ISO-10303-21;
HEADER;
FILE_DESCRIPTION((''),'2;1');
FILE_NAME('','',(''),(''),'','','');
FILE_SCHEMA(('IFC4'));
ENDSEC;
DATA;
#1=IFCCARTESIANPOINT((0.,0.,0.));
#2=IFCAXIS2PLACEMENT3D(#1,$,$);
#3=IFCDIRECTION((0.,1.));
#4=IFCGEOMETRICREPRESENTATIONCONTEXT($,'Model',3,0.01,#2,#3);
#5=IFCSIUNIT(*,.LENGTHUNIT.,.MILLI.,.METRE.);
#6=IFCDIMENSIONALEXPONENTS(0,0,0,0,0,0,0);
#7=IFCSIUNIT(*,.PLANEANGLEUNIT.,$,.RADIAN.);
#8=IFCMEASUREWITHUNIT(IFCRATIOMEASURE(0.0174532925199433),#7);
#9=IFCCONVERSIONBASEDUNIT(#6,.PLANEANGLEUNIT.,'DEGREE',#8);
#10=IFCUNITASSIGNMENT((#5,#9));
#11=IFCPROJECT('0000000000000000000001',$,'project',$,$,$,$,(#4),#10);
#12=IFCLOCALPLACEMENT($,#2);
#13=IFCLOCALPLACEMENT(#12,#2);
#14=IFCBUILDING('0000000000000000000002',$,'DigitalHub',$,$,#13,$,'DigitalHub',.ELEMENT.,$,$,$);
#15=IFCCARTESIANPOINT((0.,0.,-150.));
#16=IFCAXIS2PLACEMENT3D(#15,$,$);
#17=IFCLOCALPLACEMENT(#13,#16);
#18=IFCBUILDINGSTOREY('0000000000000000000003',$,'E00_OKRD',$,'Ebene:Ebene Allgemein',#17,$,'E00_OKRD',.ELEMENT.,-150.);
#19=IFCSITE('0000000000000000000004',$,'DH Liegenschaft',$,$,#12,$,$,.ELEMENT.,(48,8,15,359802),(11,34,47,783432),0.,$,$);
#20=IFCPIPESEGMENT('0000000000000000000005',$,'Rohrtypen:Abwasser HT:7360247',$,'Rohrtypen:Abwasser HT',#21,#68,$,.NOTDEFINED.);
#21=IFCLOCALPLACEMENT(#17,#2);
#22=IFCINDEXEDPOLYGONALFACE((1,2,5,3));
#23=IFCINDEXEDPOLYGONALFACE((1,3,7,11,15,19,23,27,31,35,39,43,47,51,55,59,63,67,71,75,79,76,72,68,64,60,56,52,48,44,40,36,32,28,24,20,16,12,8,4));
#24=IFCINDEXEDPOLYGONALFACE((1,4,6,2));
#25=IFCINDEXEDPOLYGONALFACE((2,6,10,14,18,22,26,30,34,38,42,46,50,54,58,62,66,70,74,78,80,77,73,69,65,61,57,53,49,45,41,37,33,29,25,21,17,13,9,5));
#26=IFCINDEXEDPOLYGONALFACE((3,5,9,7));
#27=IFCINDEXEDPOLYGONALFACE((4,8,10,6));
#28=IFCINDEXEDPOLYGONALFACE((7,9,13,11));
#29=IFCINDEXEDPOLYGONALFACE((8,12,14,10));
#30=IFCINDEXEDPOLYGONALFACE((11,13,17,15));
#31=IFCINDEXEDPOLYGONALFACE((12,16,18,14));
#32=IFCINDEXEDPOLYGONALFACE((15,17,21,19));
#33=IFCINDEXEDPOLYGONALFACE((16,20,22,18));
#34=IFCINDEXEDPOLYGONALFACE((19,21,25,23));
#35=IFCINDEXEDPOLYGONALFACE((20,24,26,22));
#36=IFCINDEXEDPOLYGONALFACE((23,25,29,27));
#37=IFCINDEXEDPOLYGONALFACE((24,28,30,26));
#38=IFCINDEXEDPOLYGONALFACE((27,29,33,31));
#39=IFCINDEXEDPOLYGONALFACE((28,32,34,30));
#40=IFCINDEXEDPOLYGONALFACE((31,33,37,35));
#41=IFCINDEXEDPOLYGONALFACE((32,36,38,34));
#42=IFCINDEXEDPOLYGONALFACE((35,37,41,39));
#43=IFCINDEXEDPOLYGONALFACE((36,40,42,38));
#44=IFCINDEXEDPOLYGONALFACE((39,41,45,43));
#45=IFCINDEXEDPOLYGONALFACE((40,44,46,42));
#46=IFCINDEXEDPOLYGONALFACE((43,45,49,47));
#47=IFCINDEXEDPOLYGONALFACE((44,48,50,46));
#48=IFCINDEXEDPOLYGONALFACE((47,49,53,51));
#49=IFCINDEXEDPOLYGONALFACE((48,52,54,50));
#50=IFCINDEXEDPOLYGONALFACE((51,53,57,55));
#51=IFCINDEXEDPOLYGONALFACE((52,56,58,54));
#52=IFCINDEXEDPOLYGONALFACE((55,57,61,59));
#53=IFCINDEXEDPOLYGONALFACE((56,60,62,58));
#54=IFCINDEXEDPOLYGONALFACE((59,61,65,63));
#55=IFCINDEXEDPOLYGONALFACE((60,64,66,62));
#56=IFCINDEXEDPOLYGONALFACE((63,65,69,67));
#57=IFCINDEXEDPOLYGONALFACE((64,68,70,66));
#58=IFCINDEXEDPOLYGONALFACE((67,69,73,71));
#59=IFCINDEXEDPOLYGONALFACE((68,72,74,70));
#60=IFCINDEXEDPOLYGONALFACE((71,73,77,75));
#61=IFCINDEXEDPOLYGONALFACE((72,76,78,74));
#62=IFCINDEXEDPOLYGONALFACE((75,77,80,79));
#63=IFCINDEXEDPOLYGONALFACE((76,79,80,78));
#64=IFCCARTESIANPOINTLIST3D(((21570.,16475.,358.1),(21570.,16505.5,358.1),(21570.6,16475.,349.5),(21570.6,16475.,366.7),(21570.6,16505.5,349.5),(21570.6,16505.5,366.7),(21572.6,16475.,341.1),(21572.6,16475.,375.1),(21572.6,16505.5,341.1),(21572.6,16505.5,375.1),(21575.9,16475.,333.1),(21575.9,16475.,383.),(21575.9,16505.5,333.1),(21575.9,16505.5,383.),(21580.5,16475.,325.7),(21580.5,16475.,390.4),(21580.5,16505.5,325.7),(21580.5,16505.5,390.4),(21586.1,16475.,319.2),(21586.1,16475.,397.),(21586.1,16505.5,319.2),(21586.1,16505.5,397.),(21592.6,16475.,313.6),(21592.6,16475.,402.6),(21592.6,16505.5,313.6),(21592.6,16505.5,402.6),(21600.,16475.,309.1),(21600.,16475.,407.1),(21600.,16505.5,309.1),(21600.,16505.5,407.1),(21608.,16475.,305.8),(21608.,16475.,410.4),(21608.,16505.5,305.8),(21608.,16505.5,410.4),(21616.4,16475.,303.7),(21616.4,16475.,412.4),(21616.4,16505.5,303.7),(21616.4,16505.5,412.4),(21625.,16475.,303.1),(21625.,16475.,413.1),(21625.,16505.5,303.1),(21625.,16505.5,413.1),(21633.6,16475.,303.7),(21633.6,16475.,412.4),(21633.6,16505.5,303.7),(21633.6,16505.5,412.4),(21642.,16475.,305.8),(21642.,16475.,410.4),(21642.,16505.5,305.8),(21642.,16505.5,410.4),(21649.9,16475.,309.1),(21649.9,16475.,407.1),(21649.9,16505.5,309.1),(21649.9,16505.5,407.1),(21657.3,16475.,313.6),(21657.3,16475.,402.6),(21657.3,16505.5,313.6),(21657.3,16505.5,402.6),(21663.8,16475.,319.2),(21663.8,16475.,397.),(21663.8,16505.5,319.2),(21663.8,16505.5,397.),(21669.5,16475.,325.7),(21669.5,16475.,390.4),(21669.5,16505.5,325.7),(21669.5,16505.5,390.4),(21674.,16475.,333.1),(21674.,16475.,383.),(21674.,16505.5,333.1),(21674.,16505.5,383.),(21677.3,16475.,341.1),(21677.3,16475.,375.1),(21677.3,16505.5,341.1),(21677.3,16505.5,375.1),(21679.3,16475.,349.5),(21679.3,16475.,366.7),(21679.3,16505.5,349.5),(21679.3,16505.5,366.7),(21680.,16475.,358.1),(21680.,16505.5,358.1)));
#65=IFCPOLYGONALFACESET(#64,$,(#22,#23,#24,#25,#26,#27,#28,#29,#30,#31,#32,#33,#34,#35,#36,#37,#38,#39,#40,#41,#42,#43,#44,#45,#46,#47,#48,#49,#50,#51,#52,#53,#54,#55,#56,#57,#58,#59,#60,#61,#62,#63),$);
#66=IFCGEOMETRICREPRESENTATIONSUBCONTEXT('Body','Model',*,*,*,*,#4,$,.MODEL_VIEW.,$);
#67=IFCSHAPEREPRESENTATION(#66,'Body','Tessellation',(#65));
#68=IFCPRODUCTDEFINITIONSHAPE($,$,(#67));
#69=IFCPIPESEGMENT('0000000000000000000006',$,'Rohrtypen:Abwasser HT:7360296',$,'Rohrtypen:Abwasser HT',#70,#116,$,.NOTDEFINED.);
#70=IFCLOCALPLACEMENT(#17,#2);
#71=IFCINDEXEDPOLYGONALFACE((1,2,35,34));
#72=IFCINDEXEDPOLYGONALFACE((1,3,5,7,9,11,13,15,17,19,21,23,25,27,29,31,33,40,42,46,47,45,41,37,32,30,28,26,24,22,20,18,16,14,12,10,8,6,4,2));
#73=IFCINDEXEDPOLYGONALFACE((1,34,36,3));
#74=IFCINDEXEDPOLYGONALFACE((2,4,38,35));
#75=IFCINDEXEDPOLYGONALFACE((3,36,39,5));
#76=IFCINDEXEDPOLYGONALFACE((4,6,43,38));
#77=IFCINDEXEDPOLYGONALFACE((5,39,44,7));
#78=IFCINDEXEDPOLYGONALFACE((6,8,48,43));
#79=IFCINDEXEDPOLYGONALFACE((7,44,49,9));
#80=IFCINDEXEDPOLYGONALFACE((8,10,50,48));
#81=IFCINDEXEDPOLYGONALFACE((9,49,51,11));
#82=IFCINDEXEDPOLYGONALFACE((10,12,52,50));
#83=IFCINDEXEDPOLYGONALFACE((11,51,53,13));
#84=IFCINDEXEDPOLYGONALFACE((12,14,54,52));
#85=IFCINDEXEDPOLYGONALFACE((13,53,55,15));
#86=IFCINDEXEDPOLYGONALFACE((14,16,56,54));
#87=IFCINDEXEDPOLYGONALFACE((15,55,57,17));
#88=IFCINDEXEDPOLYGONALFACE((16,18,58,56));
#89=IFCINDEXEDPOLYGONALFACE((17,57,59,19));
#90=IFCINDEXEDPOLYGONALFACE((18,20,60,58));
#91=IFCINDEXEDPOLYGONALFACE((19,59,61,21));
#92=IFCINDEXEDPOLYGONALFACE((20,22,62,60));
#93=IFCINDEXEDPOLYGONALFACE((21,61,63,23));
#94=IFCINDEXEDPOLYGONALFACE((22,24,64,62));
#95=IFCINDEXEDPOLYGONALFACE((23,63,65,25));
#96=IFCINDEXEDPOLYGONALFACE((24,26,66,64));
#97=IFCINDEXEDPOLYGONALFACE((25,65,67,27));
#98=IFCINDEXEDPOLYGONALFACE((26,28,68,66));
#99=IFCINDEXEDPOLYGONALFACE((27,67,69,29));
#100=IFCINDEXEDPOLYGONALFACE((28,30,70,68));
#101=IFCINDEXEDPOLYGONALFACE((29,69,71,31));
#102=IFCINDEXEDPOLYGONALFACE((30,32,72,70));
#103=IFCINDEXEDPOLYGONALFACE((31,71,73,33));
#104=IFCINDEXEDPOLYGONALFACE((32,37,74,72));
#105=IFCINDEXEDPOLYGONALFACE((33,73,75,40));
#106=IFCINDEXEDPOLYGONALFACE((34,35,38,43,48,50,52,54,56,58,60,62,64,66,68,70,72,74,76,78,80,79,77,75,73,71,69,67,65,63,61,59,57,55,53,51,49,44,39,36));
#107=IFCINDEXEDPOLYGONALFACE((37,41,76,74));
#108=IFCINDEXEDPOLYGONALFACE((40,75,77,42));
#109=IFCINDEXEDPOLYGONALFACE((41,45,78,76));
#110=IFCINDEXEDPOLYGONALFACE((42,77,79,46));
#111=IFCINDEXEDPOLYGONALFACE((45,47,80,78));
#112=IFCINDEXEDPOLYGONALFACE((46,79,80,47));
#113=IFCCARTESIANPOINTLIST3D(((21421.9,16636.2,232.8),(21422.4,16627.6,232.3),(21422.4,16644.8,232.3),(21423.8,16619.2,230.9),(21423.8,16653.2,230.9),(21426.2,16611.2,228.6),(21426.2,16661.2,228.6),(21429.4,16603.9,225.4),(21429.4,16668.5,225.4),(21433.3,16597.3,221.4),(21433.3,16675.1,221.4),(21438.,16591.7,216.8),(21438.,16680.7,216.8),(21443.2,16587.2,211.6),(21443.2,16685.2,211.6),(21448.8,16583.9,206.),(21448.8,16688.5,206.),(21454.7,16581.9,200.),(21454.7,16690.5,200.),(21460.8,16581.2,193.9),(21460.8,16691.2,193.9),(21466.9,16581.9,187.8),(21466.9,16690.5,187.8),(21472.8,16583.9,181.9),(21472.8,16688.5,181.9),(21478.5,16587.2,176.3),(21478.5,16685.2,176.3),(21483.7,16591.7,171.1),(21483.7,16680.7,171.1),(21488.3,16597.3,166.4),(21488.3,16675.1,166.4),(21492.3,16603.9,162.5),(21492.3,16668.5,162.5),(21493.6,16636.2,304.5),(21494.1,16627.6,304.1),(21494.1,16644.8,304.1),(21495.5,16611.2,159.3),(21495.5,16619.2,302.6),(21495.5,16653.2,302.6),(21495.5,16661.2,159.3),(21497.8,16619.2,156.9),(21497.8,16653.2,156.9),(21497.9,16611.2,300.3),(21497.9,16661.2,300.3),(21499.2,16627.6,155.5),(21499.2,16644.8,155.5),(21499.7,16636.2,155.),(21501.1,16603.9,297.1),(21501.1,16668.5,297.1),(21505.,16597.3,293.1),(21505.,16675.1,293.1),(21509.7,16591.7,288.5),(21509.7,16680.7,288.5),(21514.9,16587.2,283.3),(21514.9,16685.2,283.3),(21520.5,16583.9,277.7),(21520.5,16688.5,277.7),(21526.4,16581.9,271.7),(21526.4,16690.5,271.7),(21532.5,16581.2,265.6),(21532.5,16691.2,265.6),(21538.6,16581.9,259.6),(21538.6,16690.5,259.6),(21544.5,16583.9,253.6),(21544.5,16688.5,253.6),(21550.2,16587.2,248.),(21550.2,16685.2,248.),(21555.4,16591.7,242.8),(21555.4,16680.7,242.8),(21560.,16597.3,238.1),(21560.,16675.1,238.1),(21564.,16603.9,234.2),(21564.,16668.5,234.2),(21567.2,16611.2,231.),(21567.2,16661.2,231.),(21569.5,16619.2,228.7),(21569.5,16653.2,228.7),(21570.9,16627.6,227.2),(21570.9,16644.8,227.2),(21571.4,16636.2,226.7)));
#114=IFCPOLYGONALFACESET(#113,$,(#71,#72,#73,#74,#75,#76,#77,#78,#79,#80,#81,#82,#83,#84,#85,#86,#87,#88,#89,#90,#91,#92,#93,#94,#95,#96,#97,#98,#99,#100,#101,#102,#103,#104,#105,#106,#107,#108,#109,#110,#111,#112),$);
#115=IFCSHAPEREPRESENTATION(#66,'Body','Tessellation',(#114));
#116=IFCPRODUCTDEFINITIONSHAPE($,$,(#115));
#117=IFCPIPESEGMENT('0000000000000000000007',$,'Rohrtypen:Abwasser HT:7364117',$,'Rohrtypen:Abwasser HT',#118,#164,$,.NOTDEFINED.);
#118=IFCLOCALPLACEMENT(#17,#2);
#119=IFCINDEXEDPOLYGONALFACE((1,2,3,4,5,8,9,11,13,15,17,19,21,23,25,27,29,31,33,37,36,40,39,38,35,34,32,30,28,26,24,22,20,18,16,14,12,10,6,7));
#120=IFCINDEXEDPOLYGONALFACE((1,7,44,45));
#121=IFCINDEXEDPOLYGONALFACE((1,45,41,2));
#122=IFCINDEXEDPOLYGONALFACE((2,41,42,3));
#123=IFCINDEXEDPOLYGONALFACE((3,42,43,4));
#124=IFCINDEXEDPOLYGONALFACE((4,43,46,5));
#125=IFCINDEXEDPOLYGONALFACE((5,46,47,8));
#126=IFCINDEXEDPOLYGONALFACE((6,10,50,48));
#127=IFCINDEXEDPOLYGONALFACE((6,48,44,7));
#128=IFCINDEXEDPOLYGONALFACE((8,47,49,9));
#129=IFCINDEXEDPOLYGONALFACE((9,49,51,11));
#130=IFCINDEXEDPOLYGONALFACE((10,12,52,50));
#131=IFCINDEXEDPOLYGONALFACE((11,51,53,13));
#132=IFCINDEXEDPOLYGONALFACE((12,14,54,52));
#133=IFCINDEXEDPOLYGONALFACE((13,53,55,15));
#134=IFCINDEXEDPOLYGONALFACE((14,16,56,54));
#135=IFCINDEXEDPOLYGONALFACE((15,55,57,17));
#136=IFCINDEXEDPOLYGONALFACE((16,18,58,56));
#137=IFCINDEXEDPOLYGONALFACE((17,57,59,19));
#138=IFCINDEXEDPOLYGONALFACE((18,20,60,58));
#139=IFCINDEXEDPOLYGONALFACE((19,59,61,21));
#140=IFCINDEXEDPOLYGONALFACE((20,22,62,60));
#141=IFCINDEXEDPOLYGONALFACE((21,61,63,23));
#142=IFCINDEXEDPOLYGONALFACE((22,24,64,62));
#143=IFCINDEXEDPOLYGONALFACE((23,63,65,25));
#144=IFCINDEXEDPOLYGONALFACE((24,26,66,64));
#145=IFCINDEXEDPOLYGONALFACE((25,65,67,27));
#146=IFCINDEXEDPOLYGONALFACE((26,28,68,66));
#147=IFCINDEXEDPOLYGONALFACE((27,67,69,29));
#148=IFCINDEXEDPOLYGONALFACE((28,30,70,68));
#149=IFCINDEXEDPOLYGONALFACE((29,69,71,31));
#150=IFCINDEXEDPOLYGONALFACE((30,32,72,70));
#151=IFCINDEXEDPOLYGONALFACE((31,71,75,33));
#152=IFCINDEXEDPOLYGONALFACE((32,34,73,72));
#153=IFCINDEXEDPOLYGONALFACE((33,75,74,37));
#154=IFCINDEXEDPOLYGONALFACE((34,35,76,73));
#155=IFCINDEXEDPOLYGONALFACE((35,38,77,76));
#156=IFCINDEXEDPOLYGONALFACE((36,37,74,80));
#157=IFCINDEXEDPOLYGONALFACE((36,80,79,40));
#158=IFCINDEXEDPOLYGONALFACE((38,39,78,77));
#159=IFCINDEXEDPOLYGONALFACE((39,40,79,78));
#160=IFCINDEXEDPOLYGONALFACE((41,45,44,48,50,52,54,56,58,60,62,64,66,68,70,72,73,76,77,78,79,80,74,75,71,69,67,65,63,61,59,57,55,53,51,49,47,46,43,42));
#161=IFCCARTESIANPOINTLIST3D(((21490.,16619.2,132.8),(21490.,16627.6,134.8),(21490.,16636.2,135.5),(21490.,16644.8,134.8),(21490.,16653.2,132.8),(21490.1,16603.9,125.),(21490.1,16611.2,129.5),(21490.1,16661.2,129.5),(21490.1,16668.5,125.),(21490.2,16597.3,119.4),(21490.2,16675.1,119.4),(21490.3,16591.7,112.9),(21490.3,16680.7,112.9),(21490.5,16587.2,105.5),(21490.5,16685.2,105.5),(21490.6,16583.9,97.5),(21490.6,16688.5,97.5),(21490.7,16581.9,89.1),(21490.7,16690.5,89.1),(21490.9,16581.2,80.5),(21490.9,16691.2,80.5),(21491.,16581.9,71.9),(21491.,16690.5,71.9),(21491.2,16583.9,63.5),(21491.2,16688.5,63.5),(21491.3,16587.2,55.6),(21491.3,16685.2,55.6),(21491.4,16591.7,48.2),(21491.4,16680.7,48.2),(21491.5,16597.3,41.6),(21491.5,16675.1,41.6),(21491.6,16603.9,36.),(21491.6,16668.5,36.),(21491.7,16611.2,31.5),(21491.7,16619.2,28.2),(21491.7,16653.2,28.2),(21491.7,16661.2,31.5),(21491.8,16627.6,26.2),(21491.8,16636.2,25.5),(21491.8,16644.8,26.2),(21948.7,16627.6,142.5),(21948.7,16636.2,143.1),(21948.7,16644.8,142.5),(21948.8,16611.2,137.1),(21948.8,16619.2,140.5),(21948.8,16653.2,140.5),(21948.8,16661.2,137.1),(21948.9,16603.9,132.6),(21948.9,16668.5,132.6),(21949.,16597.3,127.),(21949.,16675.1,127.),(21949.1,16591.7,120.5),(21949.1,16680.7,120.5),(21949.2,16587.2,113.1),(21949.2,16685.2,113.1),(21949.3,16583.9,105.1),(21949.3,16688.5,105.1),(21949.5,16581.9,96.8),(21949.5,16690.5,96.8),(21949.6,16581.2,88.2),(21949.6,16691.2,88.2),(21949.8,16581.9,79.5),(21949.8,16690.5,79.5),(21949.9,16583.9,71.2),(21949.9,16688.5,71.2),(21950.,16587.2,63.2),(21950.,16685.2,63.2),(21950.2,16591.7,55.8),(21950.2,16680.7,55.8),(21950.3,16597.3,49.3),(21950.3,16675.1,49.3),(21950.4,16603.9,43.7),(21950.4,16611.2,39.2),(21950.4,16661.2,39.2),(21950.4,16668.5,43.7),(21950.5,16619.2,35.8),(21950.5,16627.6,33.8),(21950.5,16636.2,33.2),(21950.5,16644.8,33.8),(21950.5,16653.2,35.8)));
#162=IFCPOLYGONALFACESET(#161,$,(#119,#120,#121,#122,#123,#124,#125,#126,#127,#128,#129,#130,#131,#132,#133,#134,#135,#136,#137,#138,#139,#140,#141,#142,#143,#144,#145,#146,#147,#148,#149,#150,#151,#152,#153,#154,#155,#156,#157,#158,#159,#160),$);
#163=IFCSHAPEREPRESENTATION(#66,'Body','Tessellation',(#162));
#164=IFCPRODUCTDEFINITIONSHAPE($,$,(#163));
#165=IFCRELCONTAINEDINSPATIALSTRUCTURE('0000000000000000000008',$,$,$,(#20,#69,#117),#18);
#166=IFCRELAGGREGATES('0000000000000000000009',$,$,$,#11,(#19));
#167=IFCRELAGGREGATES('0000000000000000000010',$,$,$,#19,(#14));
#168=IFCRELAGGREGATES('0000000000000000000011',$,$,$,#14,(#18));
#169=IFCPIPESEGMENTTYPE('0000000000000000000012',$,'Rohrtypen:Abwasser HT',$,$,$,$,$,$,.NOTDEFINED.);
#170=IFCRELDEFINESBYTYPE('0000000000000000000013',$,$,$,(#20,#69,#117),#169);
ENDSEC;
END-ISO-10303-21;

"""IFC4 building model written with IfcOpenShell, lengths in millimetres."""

from ifc_helpers import new_model, entity, si_unit, converted_unit, direction, frame, origin, place, context, subcontext, project, spatial, indexed_curve, outline, extrude, type_object, element, save


model = new_model("IFC4")

# Units and contexts
model_context = context("Model", 3, precision=0.01, world=origin(), true_north=direction((0.0, 1.0)))
body_context = subcontext(model_context, "Body", "Model", "MODEL_VIEW")
ifc_project = project(units=[si_unit("LENGTHUNIT", "METRE", prefix="MILLI"), converted_unit("PLANEANGLEUNIT", "DEGREE", entity("IfcRatioMeasure", 0.0174532925199433), si_unit("PLANEANGLEUNIT", "RADIAN"), dimensions=[0, 0, 0, 0, 0, 0, 0])], contexts=[model_context])

# Site, building, storey
site_placement = place(None, origin())
site = spatial("IfcSite", under=ifc_project, at=site_placement, Name="DH Liegenschaft", CompositionType="ELEMENT", RefLatitude=(48, 8, 15, 359802), RefLongitude=(11, 34, 47, 783432), RefElevation=0.0)
building_placement = place(site_placement, origin())
building = spatial("IfcBuilding", under=site, at=building_placement, Name="DigitalHub", LongName="DigitalHub", CompositionType="ELEMENT")
storey_placement = place(building_placement, frame((0.0, 0.0, -150.0)))
storey = spatial("IfcBuildingStorey", under=building, at=storey_placement, Name="E00_OKRD", ObjectType="Ebene:Ebene Allgemein", LongName="E00_OKRD", CompositionType="ELEMENT", Elevation=-150.0)

# Pipe segments
pipe_segment_type_1 = type_object("IfcPipeSegmentType", Name="Rohrtypen:Abwasser HT", PredefinedType="NOTDEFINED")
pipe_segment_1_placement = place(storey_placement, frame((21568.4, 16475.0, 301.5)))
element("IfcPipeSegment", 1, at=pipe_segment_1_placement, inside=storey, type_object=pipe_segment_type_1, Name="Rohrtypen:Abwasser HT:7360247", ObjectType="Rohrtypen:Abwasser HT", PredefinedType="NOTDEFINED", context=body_context, shape_type="SweptSolid", body=[
    extrude(outline(indexed_curve([(55.0, 0.0), (54.3, 8.6), (52.3, 17.0), (49.0, 25.0), (44.5, 32.3), (38.9, 38.9), (32.3, 44.5), (25.0, 49.0), (17.0, 52.3), (8.6, 54.3), (0.0, 55.0), (-8.6, 54.3), (-17.0, 52.3), (-25.0, 49.0), (-32.3, 44.5), (-38.9, 38.9), (-44.5, 32.3), (-49.0, 25.0), (-52.3, 17.0), (-54.3, 8.6), (-55.0, 0.0), (-54.3, -8.6), (-52.3, -17.0), (-49.0, -25.0), (-44.5, -32.3), (-38.9, -38.9), (-32.3, -44.5), (-25.0, -49.0), (-17.0, -52.3), (-8.6, -54.3), (0.0, -55.0), (8.6, -54.3), (17.0, -52.3), (25.0, -49.0), (32.3, -44.5), (38.9, -38.9), (44.5, -32.3), (49.0, -25.0), (52.3, -17.0), (54.3, -8.6), (55.0, 0.0)], self_intersect=False)), frame((56.6, 0.0, 56.6), z_axis=(0.0, 1.0, 0.0), x_axis=(1.0, 0.0, 0.0)), (0.0, 0.0, 1.0), 30.5),
])
pipe_segment_2_placement = place(storey_placement, frame((21420.3, 16579.6, 153.4)))
element("IfcPipeSegment", 2, at=pipe_segment_2_placement, inside=storey, type_object=pipe_segment_type_1, Name="Rohrtypen:Abwasser HT:7360296", ObjectType="Rohrtypen:Abwasser HT", PredefinedType="NOTDEFINED", context=body_context, shape_type="SweptSolid", body=[
    extrude(outline(indexed_curve([(55.0, 0.0), (54.3, 8.6), (52.3, 17.0), (49.0, 25.0), (44.5, 32.3), (38.9, 38.9), (32.3, 44.5), (25.0, 49.0), (17.0, 52.3), (8.6, 54.3), (0.0, 55.0), (-8.6, 54.3), (-17.0, 52.3), (-25.0, 49.0), (-32.3, 44.5), (-38.9, 38.9), (-44.5, 32.3), (-49.0, 25.0), (-52.3, 17.0), (-54.3, 8.6), (-55.0, 0.0), (-54.3, -8.6), (-52.3, -17.0), (-49.0, -25.0), (-44.5, -32.3), (-38.9, -38.9), (-32.3, -44.5), (-25.0, -49.0), (-17.0, -52.3), (-8.6, -54.3), (0.0, -55.0), (8.6, -54.3), (17.0, -52.3), (25.0, -49.0), (32.3, -44.5), (38.9, -38.9), (44.5, -32.3), (49.0, -25.0), (52.3, -17.0), (54.3, -8.6), (55.0, 0.0)], self_intersect=False)), frame((40.5, 56.6, 40.5), z_axis=(0.707107, 0.0, 0.707107), x_axis=(0.0, 1.0, 0.0)), (0.0, 0.0, 1.0), 101.4),
])
pipe_segment_3_placement = place(storey_placement, frame((21488.4, 16579.6, 23.9)))
element("IfcPipeSegment", 3, at=pipe_segment_3_placement, inside=storey, type_object=pipe_segment_type_1, Name="Rohrtypen:Abwasser HT:7364117", ObjectType="Rohrtypen:Abwasser HT", PredefinedType="NOTDEFINED", context=body_context, shape_type="SweptSolid", body=[
    extrude(outline(indexed_curve([(55.0, 0.0), (54.3, 8.6), (52.3, 17.0), (49.0, 25.0), (44.5, 32.3), (38.9, 38.9), (32.3, 44.5), (25.0, 49.0), (17.0, 52.3), (8.6, 54.3), (0.0, 55.0), (-8.6, 54.3), (-17.0, 52.3), (-25.0, 49.0), (-32.3, 44.5), (-38.9, 38.9), (-44.5, 32.3), (-49.0, 25.0), (-52.3, 17.0), (-54.3, 8.6), (-55.0, 0.0), (-54.3, -8.6), (-52.3, -17.0), (-49.0, -25.0), (-44.5, -32.3), (-38.9, -38.9), (-32.3, -44.5), (-25.0, -49.0), (-17.0, -52.3), (-8.6, -54.3), (0.0, -55.0), (8.6, -54.3), (17.0, -52.3), (25.0, -49.0), (32.3, -44.5), (38.9, -38.9), (44.5, -32.3), (49.0, -25.0), (52.3, -17.0), (54.3, -8.6), (55.0, 0.0)], self_intersect=False)), frame((2.5, 56.6, 56.6), z_axis=(0.999862, 0.0, 0.016604), x_axis=(0.0, 1.0, 0.0)), (0.0, 0.0, 1.0), 458.8),
])

save(model, "model.ifc")
